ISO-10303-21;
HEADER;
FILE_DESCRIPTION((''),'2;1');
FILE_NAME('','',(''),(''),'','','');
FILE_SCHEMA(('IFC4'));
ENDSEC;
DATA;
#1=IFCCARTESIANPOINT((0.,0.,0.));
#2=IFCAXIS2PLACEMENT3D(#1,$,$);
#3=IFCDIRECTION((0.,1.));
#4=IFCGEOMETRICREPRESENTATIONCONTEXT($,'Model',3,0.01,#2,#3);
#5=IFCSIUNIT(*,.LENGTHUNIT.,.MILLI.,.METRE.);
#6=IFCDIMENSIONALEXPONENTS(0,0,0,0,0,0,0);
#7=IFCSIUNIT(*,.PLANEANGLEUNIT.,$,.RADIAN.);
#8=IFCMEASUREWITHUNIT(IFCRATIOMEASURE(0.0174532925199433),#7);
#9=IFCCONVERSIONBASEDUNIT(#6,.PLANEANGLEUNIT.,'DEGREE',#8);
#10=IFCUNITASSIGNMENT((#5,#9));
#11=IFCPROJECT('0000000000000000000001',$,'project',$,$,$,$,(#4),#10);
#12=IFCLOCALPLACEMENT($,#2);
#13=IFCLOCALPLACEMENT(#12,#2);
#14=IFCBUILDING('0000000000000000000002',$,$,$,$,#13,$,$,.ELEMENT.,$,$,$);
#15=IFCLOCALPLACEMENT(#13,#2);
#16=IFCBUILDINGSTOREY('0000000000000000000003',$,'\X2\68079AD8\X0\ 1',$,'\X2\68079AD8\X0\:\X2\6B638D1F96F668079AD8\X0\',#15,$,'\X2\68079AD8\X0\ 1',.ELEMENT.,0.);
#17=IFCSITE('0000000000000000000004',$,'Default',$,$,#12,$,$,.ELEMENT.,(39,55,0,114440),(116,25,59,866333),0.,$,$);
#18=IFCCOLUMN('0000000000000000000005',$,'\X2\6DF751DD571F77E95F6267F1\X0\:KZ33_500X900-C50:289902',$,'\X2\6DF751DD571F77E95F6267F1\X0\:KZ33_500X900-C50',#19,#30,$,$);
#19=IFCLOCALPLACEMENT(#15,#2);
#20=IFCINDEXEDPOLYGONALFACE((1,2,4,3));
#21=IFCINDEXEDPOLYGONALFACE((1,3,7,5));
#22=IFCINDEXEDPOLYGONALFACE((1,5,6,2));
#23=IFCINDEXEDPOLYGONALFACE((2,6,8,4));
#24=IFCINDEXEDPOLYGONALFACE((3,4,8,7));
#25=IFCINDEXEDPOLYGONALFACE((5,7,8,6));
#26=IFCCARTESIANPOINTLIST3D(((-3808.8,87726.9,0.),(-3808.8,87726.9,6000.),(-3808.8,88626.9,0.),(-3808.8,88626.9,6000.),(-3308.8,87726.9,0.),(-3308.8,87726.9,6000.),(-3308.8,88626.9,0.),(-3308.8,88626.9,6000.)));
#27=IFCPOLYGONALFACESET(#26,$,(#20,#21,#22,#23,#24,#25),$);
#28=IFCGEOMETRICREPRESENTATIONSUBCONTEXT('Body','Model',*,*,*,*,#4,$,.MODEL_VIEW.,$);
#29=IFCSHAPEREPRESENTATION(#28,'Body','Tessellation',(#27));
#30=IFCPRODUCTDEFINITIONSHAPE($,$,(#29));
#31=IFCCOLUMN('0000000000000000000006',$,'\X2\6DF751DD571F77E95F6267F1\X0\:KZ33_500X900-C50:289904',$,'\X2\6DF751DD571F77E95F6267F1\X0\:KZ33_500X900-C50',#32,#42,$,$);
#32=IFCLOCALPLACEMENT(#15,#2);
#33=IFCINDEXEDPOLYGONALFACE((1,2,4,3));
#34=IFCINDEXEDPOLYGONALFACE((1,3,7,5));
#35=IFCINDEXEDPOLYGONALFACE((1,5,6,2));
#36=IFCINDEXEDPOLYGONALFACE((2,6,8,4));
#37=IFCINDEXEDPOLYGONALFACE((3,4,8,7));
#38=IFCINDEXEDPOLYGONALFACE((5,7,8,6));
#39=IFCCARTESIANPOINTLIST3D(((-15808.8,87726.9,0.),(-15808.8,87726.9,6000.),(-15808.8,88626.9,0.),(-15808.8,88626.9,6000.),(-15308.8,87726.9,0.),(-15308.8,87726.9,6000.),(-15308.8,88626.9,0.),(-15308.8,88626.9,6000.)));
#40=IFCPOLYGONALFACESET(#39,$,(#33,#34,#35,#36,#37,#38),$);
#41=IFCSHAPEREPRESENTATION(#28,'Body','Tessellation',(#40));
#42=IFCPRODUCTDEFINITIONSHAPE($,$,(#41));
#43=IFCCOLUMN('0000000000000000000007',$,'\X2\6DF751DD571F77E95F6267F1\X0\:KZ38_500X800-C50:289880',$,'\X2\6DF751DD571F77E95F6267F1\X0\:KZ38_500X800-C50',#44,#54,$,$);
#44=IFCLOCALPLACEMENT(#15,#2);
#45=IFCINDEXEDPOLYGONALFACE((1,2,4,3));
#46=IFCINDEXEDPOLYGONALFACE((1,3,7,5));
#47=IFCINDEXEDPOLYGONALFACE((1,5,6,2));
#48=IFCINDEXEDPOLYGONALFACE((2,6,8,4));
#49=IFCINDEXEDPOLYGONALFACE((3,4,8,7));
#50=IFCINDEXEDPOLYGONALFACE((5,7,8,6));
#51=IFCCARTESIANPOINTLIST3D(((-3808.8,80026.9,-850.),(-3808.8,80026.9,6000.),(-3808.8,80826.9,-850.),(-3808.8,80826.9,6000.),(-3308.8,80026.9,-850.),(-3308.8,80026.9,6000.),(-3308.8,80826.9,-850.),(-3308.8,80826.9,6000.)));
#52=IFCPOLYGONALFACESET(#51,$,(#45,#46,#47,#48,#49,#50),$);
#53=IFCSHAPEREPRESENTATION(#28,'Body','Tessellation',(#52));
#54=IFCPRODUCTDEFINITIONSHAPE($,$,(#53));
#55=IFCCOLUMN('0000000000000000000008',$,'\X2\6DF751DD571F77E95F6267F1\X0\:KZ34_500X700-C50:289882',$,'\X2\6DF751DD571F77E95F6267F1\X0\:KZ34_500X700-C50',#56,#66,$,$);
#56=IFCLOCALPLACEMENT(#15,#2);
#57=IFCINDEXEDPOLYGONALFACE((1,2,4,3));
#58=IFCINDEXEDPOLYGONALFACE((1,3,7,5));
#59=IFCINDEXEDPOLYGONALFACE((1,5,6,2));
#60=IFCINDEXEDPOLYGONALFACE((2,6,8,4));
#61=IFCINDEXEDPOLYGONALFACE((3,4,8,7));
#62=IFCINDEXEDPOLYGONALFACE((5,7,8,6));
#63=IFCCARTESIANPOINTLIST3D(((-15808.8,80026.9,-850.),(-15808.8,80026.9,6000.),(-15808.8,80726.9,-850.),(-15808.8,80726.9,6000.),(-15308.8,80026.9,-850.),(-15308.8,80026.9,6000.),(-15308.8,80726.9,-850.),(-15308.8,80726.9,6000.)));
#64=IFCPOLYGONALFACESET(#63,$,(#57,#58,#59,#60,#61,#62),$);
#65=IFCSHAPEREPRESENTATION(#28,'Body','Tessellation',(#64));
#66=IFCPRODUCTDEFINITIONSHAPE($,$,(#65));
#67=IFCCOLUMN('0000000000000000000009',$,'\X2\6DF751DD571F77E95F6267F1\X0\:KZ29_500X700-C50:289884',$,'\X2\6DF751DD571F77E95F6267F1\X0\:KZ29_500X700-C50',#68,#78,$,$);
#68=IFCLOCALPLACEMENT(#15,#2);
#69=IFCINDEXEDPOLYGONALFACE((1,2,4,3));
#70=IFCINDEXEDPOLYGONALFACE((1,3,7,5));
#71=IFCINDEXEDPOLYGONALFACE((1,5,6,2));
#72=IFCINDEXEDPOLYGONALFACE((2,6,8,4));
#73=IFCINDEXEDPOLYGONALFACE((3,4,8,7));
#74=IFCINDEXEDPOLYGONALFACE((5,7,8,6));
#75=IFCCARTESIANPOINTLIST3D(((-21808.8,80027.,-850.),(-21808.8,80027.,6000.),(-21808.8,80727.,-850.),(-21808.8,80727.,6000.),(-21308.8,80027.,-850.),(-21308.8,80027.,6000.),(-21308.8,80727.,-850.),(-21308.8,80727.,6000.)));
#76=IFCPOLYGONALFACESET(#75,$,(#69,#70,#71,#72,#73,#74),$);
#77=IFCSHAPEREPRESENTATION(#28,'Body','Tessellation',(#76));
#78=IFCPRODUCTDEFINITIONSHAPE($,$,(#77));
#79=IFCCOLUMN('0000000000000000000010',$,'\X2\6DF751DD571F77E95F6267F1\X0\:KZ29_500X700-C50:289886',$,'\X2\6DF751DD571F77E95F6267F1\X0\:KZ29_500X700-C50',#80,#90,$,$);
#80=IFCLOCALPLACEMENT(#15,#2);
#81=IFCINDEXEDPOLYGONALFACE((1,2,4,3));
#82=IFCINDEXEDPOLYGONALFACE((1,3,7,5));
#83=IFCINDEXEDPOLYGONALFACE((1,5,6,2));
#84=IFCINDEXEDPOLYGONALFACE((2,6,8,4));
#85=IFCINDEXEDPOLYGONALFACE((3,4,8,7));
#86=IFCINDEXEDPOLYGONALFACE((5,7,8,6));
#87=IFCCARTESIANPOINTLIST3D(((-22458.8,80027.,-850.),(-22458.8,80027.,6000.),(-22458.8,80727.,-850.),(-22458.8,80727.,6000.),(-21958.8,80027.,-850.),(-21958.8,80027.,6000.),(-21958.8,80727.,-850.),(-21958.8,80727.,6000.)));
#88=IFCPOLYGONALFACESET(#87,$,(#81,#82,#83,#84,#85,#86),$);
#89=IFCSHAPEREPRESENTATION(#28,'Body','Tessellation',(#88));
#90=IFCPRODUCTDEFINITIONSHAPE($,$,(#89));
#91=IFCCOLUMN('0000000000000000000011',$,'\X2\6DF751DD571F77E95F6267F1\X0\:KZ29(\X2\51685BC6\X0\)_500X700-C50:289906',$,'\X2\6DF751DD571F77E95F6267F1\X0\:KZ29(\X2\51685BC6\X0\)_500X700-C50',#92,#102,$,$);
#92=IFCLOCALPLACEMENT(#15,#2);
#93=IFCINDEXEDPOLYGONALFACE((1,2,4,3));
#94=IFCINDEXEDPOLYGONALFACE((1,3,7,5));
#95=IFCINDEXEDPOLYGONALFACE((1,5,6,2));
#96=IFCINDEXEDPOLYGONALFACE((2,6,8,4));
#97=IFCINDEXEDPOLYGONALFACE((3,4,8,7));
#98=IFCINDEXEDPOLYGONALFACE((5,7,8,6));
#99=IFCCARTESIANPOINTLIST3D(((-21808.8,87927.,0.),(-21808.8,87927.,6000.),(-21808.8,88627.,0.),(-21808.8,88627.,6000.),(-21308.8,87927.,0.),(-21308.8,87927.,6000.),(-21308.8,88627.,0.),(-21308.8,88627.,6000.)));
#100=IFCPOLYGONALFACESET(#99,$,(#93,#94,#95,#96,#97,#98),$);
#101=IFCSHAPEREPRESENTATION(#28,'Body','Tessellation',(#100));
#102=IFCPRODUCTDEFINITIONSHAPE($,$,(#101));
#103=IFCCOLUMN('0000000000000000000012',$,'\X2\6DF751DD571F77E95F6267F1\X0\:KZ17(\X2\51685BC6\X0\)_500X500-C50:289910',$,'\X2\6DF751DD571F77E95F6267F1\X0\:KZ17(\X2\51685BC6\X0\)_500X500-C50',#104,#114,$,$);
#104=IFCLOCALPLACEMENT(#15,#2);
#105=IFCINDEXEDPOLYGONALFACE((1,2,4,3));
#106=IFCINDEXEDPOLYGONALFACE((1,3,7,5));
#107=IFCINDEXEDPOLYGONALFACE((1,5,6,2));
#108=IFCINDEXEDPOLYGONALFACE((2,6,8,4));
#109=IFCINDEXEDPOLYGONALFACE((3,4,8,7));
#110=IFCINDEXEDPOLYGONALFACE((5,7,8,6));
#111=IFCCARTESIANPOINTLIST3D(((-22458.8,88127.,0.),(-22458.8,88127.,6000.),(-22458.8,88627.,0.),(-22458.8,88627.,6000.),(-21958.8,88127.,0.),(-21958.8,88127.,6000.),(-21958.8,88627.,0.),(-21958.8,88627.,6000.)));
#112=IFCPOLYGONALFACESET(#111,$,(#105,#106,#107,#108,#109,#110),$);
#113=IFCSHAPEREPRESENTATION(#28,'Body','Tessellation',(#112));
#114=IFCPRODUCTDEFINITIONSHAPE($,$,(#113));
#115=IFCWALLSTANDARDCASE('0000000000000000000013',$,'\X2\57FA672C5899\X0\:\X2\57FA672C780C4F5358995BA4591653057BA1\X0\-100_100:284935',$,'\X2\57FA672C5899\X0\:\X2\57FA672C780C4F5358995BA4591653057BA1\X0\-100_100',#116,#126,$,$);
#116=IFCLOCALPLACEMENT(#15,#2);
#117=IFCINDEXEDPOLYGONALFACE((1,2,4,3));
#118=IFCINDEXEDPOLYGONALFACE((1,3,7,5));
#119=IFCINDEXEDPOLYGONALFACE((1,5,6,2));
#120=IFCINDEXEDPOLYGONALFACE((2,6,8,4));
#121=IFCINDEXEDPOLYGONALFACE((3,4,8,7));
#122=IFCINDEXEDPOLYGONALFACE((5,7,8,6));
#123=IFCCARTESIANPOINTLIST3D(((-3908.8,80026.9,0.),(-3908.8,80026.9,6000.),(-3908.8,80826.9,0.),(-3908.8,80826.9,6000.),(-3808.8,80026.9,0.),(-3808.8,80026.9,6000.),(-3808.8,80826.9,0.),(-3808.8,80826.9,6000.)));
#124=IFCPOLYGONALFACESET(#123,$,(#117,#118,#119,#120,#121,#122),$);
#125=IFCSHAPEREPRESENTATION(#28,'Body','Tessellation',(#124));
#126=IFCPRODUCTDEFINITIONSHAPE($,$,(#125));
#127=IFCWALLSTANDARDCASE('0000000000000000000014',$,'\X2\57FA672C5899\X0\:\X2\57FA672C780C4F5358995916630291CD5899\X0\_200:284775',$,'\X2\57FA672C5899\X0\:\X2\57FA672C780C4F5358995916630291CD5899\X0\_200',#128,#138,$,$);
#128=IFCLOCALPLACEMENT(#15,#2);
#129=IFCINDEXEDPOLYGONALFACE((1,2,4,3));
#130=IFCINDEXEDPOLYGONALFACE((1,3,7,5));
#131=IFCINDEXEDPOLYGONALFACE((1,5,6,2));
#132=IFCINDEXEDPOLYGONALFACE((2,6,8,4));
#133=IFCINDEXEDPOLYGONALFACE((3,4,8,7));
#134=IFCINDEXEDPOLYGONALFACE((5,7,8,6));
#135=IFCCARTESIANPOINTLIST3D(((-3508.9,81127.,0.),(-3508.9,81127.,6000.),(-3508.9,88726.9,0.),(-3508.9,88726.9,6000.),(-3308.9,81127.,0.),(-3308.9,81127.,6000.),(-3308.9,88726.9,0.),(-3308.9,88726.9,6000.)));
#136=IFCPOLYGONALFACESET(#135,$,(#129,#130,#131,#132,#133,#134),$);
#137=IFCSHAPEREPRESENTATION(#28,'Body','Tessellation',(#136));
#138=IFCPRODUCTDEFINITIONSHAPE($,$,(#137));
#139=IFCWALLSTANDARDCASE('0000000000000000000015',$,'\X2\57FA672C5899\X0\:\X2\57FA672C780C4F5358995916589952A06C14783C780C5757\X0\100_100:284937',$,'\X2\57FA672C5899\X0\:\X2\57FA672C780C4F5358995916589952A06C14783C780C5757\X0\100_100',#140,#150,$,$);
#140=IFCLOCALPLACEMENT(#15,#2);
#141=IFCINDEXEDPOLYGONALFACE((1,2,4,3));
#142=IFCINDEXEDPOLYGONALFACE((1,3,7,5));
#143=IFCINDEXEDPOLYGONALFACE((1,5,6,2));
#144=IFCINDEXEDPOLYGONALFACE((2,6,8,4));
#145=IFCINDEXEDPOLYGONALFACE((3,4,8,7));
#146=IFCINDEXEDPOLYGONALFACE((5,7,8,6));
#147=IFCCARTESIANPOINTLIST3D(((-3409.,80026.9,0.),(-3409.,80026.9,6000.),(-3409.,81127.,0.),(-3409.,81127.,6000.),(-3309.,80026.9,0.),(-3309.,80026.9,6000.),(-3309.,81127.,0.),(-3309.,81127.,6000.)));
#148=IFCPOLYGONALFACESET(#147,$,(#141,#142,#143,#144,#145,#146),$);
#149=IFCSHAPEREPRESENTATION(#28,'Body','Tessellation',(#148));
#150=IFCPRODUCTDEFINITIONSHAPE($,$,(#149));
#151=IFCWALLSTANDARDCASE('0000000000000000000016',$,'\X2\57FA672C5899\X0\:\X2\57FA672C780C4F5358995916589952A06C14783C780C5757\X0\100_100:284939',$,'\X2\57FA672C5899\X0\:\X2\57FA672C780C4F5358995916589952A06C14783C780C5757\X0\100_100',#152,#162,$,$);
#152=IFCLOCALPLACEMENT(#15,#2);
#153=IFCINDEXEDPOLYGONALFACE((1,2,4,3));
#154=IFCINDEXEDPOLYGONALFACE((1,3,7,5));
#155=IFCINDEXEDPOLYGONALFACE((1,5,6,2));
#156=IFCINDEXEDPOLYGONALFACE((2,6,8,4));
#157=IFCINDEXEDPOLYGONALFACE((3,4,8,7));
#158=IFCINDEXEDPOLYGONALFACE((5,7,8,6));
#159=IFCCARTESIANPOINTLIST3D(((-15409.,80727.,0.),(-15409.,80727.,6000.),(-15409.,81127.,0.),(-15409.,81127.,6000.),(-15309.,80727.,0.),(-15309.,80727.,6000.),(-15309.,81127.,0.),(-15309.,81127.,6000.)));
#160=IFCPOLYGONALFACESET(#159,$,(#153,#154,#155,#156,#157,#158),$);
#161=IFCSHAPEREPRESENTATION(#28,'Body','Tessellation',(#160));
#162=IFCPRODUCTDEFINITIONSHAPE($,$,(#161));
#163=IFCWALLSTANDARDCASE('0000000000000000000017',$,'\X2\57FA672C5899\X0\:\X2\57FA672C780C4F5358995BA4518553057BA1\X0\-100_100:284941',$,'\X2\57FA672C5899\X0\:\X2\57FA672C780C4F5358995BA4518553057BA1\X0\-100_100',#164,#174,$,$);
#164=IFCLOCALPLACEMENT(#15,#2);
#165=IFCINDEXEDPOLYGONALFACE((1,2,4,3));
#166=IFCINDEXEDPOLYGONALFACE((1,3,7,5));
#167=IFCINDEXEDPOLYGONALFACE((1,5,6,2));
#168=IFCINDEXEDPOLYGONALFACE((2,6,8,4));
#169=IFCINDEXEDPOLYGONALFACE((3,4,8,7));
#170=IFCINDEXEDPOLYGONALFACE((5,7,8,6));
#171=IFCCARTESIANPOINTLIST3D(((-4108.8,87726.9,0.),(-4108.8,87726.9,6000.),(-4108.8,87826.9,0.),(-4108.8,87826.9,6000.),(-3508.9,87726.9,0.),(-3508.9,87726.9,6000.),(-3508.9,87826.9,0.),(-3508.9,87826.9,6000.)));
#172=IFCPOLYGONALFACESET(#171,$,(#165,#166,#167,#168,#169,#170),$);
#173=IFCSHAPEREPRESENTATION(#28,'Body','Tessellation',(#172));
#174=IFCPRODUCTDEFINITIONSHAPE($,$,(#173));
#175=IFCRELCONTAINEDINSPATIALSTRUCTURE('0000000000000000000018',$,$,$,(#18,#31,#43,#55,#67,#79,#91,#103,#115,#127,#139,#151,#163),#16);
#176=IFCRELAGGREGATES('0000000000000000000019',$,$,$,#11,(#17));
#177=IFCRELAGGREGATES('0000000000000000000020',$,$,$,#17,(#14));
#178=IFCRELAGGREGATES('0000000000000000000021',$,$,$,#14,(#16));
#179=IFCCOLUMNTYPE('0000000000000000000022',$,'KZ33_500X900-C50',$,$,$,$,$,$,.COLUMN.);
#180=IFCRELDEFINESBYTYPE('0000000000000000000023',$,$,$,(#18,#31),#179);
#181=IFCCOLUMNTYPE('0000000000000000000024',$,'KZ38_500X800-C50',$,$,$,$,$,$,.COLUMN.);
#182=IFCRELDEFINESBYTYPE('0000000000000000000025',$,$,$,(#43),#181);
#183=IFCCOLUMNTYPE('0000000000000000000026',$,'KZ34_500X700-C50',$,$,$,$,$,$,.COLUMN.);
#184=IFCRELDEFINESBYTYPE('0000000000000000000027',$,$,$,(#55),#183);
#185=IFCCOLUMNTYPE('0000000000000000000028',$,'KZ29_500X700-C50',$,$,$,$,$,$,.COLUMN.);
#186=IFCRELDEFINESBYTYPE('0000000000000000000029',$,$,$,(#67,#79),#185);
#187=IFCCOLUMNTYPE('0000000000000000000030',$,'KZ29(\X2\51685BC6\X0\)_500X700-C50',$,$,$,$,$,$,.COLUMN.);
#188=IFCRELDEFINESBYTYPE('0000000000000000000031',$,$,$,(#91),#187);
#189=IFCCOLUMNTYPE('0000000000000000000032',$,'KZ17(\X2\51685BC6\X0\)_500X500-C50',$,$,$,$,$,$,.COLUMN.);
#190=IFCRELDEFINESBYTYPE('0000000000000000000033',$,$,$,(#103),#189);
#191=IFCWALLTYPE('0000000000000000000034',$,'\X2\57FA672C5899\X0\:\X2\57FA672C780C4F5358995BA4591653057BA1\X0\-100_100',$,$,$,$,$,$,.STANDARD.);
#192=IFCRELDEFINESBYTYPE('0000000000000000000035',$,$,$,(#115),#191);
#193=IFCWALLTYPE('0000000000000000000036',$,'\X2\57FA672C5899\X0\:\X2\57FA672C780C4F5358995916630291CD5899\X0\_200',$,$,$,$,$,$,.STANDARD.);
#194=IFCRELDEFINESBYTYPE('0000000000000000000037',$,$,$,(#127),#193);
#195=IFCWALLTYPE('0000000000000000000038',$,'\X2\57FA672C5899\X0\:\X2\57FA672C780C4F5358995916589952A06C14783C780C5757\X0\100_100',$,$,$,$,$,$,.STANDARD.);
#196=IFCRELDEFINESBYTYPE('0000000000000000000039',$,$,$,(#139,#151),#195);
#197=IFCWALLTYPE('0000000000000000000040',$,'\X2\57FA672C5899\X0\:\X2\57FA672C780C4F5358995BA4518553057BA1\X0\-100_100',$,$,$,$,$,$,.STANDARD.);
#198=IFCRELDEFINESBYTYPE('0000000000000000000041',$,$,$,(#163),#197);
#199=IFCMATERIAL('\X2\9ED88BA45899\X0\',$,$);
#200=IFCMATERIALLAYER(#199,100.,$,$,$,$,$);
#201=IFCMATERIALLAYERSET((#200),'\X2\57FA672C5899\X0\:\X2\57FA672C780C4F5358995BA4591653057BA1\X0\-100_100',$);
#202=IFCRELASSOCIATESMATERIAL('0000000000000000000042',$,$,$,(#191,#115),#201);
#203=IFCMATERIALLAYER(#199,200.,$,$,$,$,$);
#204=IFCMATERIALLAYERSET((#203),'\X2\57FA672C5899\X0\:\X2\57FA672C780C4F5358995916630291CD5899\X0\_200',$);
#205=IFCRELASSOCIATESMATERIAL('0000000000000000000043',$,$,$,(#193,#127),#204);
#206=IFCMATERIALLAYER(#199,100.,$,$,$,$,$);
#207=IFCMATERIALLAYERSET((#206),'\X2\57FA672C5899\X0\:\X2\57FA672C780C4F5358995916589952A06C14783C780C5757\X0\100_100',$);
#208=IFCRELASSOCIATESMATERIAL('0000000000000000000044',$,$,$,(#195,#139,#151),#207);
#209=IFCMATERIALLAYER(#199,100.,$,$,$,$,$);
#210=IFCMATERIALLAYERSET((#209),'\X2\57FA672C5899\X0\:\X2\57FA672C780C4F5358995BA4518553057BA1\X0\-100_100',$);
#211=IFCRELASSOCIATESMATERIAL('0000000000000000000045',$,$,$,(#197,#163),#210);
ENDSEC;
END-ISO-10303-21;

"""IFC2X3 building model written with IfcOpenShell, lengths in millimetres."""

from ifc_helpers import new_model, entity, si_unit, converted_unit, direction, frame, frame_2d, origin, origin_2d_with_axis, place, context, subcontext, project, spatial, rectangle, extrude, source, transform, mapped, material, layer, layer_set, layer_usage, type_object, type_shapes, element, save


model = new_model("IFC2X3")

# Units and contexts
model_context = context("Model", 3, precision=0.01, world=origin(), true_north=direction((0.0, 1.0)))
body_context = subcontext(model_context, "Body", "Model", "MODEL_VIEW")
ifc_project = project(units=[si_unit("LENGTHUNIT", "METRE", prefix="MILLI"), converted_unit("PLANEANGLEUNIT", "DEGREE", entity("IfcRatioMeasure", 0.0174532925199433), si_unit("PLANEANGLEUNIT", "RADIAN"), dimensions=[0, 0, 0, 0, 0, 0, 0])], contexts=[model_context])

# Site, building, storey
site_placement = place(None, origin())
site = spatial("IfcSite", under=ifc_project, at=site_placement, Name="Default", CompositionType="ELEMENT", RefLatitude=(39, 55, 0, 114440), RefLongitude=(116, 25, 59, 866333), RefElevation=0.0)
building_placement = place(site_placement, origin())
building = spatial("IfcBuilding", under=site, at=building_placement, CompositionType="ELEMENT")
storey_placement = place(building_placement, origin())
storey = spatial("IfcBuildingStorey", under=building, at=storey_placement, Name="标高 1", ObjectType="标高:正负零标高", LongName="标高 1", CompositionType="ELEMENT", Elevation=0.0)

# Columns
column_type_1 = type_object("IfcColumnType", Name="KZ33_500X900-C50", PredefinedType="COLUMN")
shared_shape_1 = source(origin(), body_context, "Body", "SweptSolid", [
    extrude(rectangle(XDim=900.0, YDim=500.0, at=origin_2d_with_axis()), frame((0.0, 0.0, 0.0), z_axis=(0.0, 0.0, 1.0), x_axis=(0.0, -1.0, 0.0)), (0.0, 0.0, 1.0), 6000.0),
])
type_shapes(column_type_1, [shared_shape_1])
for number, where, name in (
    (1, (-3558.8, 88176.9, 0.0), "混凝土矩形柱:KZ33_500X900-C50:289902"),
    (2, (-15558.8, 88176.9, 0.0), "混凝土矩形柱:KZ33_500X900-C50:289904"),
):
    element("IfcColumn", number, at=place(building_placement, frame(where)), inside=storey, type_object=column_type_1, Name=name, ObjectType="混凝土矩形柱:KZ33_500X900-C50", context=body_context, shape_type="MappedRepresentation", body=[
        mapped(shared_shape_1, transform((0.0, 0.0, 0.0), scale=1.0)),
    ])
column_type_2 = type_object("IfcColumnType", Name="KZ38_500X800-C50", PredefinedType="COLUMN")
shared_shape_2 = source(origin(), body_context, "Body", "SweptSolid", [
    extrude(rectangle(XDim=800.0, YDim=500.0, at=origin_2d_with_axis()), frame((0.0, 0.0, -850.0), z_axis=(0.0, 0.0, 1.0), x_axis=(0.0, -1.0, 0.0)), (0.0, 0.0, 1.0), 6850.0),
])
type_shapes(column_type_2, [shared_shape_2])
column_1_placement = place(building_placement, frame((-3558.8, 80426.9, 0.0)))
element("IfcColumn", 3, at=column_1_placement, inside=storey, type_object=column_type_2, Name="混凝土矩形柱:KZ38_500X800-C50:289880", ObjectType="混凝土矩形柱:KZ38_500X800-C50", context=body_context, shape_type="MappedRepresentation", body=[
    mapped(shared_shape_2, transform((0.0, 0.0, 0.0), scale=1.0)),
])
column_type_3 = type_object("IfcColumnType", Name="KZ34_500X700-C50", PredefinedType="COLUMN")
shared_shape_3 = source(origin(), body_context, "Body", "SweptSolid", [
    extrude(rectangle(XDim=700.0, YDim=500.0, at=origin_2d_with_axis()), frame((0.0, 0.0, -850.0), z_axis=(0.0, 0.0, 1.0), x_axis=(0.0, -1.0, 0.0)), (0.0, 0.0, 1.0), 6850.0),
])
type_shapes(column_type_3, [shared_shape_3])
column_2_placement = place(building_placement, frame((-15558.8, 80376.9, 0.0)))
element("IfcColumn", 4, at=column_2_placement, inside=storey, type_object=column_type_3, Name="混凝土矩形柱:KZ34_500X700-C50:289882", ObjectType="混凝土矩形柱:KZ34_500X700-C50", context=body_context, shape_type="MappedRepresentation", body=[
    mapped(shared_shape_3, transform((0.0, 0.0, 0.0), scale=1.0)),
])
column_type_4 = type_object("IfcColumnType", Name="KZ29_500X700-C50", PredefinedType="COLUMN")
shared_shape_4 = source(origin(), body_context, "Body", "SweptSolid", [
    extrude(rectangle(XDim=700.0, YDim=500.0, at=origin_2d_with_axis()), frame((0.0, 0.0, -850.0), z_axis=(0.0, 0.0, 1.0), x_axis=(0.0, -1.0, 0.0)), (0.0, 0.0, 1.0), 6850.0),
])
type_shapes(column_type_4, [shared_shape_4])
for number, where, name in (
    (5, (-21558.8, 80377.0, 0.0), "混凝土矩形柱:KZ29_500X700-C50:289884"),
    (6, (-22208.8, 80377.0, 0.0), "混凝土矩形柱:KZ29_500X700-C50:289886"),
):
    element("IfcColumn", number, at=place(building_placement, frame(where)), inside=storey, type_object=column_type_4, Name=name, ObjectType="混凝土矩形柱:KZ29_500X700-C50", context=body_context, shape_type="MappedRepresentation", body=[
        mapped(shared_shape_4, transform((0.0, 0.0, 0.0), scale=1.0)),
    ])
column_type_5 = type_object("IfcColumnType", Name="KZ29(全密)_500X700-C50", PredefinedType="COLUMN")
shared_shape_5 = source(origin(), body_context, "Body", "SweptSolid", [
    extrude(rectangle(XDim=700.0, YDim=500.0, at=origin_2d_with_axis()), frame((0.0, 0.0, 0.0), z_axis=(0.0, 0.0, 1.0), x_axis=(0.0, -1.0, 0.0)), (0.0, 0.0, 1.0), 6000.0),
])
type_shapes(column_type_5, [shared_shape_5])
column_3_placement = place(building_placement, frame((-21558.8, 88277.0, 0.0)))
element("IfcColumn", 7, at=column_3_placement, inside=storey, type_object=column_type_5, Name="混凝土矩形柱:KZ29(全密)_500X700-C50:289906", ObjectType="混凝土矩形柱:KZ29(全密)_500X700-C50", context=body_context, shape_type="MappedRepresentation", body=[
    mapped(shared_shape_5, transform((0.0, 0.0, 0.0), scale=1.0)),
])
column_type_6 = type_object("IfcColumnType", Name="KZ17(全密)_500X500-C50", PredefinedType="COLUMN")
shared_shape_6 = source(origin(), body_context, "Body", "SweptSolid", [
    extrude(rectangle(XDim=500.0, YDim=500.0, at=origin_2d_with_axis()), frame((0.0, 0.0, 0.0), z_axis=(0.0, 0.0, 1.0), x_axis=(0.0, -1.0, 0.0)), (0.0, 0.0, 1.0), 6000.0),
])
type_shapes(column_type_6, [shared_shape_6])
column_4_placement = place(building_placement, frame((-22208.8, 88377.0, 0.0)))
element("IfcColumn", 8, at=column_4_placement, inside=storey, type_object=column_type_6, Name="混凝土矩形柱:KZ17(全密)_500X500-C50:289910", ObjectType="混凝土矩形柱:KZ17(全密)_500X500-C50", context=body_context, shape_type="MappedRepresentation", body=[
    mapped(shared_shape_6, transform((0.0, 0.0, 0.0), scale=1.0)),
])

# Walls
ifc_material = material(Name="默认墙")
ifc_layer_1 = layer(ifc_material, 100.0)
ifc_layer_set_1 = layer_set([ifc_layer_1], Name="基本墙:基本砌体墙室外包管-100_100")
ifc_layer_usage_1 = layer_usage(ifc_layer_set_1, "AXIS2", "NEGATIVE", 50.0)
wall_type_1 = type_object("IfcWallType", Name="基本墙:基本砌体墙室外包管-100_100", PredefinedType="STANDARD", material=ifc_layer_set_1)
wall_1_placement = place(building_placement, frame((-3858.8, 80826.9, 0.0), z_axis=(0.0, 0.0, 1.0), x_axis=(0.0, -1.0, 0.0)))
element("IfcWallStandardCase", 9, at=wall_1_placement, inside=storey, type_object=wall_type_1, material=ifc_layer_usage_1, Name="基本墙:基本砌体墙室外包管-100_100:284935", ObjectType="基本墙:基本砌体墙室外包管-100_100", context=body_context, shape_type="SweptSolid", body=[
    extrude(rectangle(XDim=800.0, YDim=100.0, at=frame_2d((400.0, 0.0), x_axis=(-1.0, 0.0))), origin(), (0.0, 0.0, 1.0), 6000.0),
])
ifc_layer_2 = layer(ifc_material, 200.0)
ifc_layer_set_2 = layer_set([ifc_layer_2], Name="基本墙:基本砌体墙外挂重墙_200")
ifc_layer_usage_2 = layer_usage(ifc_layer_set_2, "AXIS2", "NEGATIVE", 100.0)
wall_type_2 = type_object("IfcWallType", Name="基本墙:基本砌体墙外挂重墙_200", PredefinedType="STANDARD", material=ifc_layer_set_2)
wall_2_placement = place(building_placement, frame((-3408.9, 88726.9, 0.0), z_axis=(0.0, 0.0, 1.0), x_axis=(0.0, -1.0, 0.0)))
element("IfcWallStandardCase", 10, at=wall_2_placement, inside=storey, type_object=wall_type_2, material=ifc_layer_usage_2, Name="基本墙:基本砌体墙外挂重墙_200:284775", ObjectType="基本墙:基本砌体墙外挂重墙_200", context=body_context, shape_type="SweptSolid", body=[
    extrude(rectangle(XDim=7599.9, YDim=200.0, at=frame_2d((3800.0, 0.0), x_axis=(-1.0, 0.0))), origin(), (0.0, 0.0, 1.0), 6000.0),
])
ifc_layer_3 = layer(ifc_material, 100.0)
ifc_layer_set_3 = layer_set([ifc_layer_3], Name="基本墙:基本砌体墙外墙加气砼砌块100_100")
ifc_layer_usage_3 = layer_usage(ifc_layer_set_3, "AXIS2", "NEGATIVE", 50.0)
wall_type_3 = type_object("IfcWallType", Name="基本墙:基本砌体墙外墙加气砼砌块100_100", PredefinedType="STANDARD", material=ifc_layer_set_3)
wall_3_placement = place(building_placement, frame((-3359.0, 81127.0, 0.0), z_axis=(0.0, 0.0, 1.0), x_axis=(0.0, -1.0, 0.0)))
element("IfcWallStandardCase", 11, at=wall_3_placement, inside=storey, type_object=wall_type_3, material=ifc_layer_usage_3, Name="基本墙:基本砌体墙外墙加气砼砌块100_100:284937", ObjectType="基本墙:基本砌体墙外墙加气砼砌块100_100", context=body_context, shape_type="SweptSolid", body=[
    extrude(rectangle(XDim=1100.1, YDim=100.0, at=frame_2d((550.0, 0.0), x_axis=(-1.0, 0.0))), origin(), (0.0, 0.0, 1.0), 6000.0),
])
ifc_layer_usage_4 = layer_usage(ifc_layer_set_3, "AXIS2", "NEGATIVE", 50.0)
wall_4_placement = place(building_placement, frame((-15359.0, 81127.0, 0.0), z_axis=(0.0, 0.0, 1.0), x_axis=(0.0, -1.0, 0.0)))
element("IfcWallStandardCase", 12, at=wall_4_placement, inside=storey, type_object=wall_type_3, material=ifc_layer_usage_4, Name="基本墙:基本砌体墙外墙加气砼砌块100_100:284939", ObjectType="基本墙:基本砌体墙外墙加气砼砌块100_100", context=body_context, shape_type="SweptSolid", body=[
    extrude(rectangle(XDim=400.0, YDim=100.0, at=frame_2d((200.0, 0.0), x_axis=(-1.0, 0.0))), origin(), (0.0, 0.0, 1.0), 6000.0),
])
ifc_layer_4 = layer(ifc_material, 100.0)
ifc_layer_set_4 = layer_set([ifc_layer_4], Name="基本墙:基本砌体墙室内包管-100_100")
ifc_layer_usage_5 = layer_usage(ifc_layer_set_4, "AXIS2", "NEGATIVE", 50.0)
wall_type_4 = type_object("IfcWallType", Name="基本墙:基本砌体墙室内包管-100_100", PredefinedType="STANDARD", material=ifc_layer_set_4)
wall_5_placement = place(building_placement, frame((-4108.8, 87776.9, 0.0)))
element("IfcWallStandardCase", 13, at=wall_5_placement, inside=storey, type_object=wall_type_4, material=ifc_layer_usage_5, Name="基本墙:基本砌体墙室内包管-100_100:284941", ObjectType="基本墙:基本砌体墙室内包管-100_100", context=body_context, shape_type="SweptSolid", body=[
    extrude(rectangle(XDim=599.8, YDim=100.0, at=frame_2d((299.9, 0.0), x_axis=(-1.0, 0.0))), origin(), (0.0, 0.0, 1.0), 6000.0),
])

save(model, "model.ifc")
